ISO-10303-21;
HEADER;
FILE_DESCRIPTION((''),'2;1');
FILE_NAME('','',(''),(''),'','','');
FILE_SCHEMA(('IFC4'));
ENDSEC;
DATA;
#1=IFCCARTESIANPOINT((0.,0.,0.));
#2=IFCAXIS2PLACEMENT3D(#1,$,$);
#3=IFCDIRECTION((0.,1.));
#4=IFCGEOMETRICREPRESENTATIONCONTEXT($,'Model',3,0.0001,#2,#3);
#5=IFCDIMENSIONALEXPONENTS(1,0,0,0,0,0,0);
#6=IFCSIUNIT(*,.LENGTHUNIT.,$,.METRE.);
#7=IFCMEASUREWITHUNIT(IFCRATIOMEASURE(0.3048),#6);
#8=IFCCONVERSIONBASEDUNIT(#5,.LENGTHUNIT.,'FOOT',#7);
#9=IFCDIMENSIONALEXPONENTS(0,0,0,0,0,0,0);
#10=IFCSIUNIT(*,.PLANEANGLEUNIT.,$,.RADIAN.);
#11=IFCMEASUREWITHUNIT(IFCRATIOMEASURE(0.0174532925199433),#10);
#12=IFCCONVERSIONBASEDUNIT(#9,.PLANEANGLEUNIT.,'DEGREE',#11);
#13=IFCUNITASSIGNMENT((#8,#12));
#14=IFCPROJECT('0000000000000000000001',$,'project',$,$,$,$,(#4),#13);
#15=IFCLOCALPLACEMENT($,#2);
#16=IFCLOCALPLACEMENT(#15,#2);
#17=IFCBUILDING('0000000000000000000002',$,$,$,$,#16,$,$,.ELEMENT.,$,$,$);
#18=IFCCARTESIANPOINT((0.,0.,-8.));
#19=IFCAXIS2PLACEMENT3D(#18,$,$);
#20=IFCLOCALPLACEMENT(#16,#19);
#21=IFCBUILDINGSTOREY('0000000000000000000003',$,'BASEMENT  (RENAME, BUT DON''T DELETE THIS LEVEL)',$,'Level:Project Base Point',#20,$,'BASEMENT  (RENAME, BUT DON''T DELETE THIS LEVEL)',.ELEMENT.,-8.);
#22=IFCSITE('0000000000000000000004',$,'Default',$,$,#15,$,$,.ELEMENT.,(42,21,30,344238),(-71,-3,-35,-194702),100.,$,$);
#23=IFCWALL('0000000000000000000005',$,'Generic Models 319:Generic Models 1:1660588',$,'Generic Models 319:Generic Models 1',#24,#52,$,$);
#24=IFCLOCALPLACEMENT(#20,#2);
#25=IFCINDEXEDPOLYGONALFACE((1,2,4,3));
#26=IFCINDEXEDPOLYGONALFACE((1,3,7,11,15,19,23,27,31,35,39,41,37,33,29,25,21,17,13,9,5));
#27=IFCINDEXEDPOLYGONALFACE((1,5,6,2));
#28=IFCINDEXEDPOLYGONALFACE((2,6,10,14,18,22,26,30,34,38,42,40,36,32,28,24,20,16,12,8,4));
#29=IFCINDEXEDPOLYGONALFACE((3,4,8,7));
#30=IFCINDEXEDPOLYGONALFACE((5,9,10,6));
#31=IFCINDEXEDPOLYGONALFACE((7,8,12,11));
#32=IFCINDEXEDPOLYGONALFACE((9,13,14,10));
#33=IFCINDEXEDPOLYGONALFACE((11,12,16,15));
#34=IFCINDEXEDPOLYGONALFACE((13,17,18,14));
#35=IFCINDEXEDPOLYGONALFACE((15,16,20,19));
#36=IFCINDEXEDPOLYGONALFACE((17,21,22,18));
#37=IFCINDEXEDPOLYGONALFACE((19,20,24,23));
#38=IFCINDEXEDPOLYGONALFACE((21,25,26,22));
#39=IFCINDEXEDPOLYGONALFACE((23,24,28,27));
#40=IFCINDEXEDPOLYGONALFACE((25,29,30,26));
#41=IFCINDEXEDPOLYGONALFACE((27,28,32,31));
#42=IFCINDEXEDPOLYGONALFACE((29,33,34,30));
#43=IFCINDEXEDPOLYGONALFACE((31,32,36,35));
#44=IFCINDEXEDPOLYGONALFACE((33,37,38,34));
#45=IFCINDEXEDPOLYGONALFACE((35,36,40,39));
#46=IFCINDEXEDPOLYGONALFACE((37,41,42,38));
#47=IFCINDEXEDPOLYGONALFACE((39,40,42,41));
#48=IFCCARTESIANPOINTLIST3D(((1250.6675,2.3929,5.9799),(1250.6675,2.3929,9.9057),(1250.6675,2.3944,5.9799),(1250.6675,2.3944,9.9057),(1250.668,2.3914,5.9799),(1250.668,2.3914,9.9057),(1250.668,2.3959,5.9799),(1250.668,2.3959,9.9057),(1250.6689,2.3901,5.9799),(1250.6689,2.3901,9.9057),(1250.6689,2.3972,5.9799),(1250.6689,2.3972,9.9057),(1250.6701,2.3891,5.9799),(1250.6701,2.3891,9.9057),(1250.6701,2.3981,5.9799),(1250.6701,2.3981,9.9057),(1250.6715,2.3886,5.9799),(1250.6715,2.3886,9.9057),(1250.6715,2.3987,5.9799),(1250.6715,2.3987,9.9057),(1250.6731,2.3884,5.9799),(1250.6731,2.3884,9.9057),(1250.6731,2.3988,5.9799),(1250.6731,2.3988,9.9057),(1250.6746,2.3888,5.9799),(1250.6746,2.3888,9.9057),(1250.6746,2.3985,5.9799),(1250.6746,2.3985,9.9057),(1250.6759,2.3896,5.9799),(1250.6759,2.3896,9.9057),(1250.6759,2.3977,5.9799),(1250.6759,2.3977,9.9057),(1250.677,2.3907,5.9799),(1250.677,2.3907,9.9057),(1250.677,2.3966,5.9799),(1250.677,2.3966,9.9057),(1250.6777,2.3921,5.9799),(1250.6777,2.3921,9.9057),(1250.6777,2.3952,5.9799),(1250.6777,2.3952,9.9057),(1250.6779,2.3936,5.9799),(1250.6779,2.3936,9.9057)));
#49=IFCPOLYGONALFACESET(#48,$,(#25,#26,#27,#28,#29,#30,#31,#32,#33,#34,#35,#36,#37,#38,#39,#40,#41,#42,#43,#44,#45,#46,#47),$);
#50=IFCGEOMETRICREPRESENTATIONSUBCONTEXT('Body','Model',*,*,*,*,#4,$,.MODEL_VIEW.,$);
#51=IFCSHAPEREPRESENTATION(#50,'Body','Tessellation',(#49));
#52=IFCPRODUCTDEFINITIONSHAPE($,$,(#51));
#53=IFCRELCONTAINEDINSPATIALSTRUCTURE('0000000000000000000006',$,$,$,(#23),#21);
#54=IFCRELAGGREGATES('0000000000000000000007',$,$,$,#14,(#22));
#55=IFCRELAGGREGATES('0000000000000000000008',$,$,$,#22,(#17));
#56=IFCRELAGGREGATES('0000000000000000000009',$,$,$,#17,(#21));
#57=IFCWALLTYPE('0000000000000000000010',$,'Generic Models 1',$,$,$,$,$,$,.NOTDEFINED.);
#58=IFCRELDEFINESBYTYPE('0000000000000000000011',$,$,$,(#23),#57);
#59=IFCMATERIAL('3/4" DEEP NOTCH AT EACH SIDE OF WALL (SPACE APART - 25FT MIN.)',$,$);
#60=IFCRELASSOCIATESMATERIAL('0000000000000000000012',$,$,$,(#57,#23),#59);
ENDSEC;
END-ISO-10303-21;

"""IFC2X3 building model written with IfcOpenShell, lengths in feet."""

from ifc_helpers import new_model, entity, si_unit, converted_unit, direction, frame, origin, origin_2d_with_axis, place, context, subcontext, project, spatial, circle, extrude, material, type_object, element, save


model = new_model("IFC2X3")

# Units and contexts
model_context = context("Model", 3, precision=0.0001, world=origin(), true_north=direction((0.0, 1.0)))
body_context = subcontext(model_context, "Body", "Model", "MODEL_VIEW")
ifc_project = project(units=[converted_unit("LENGTHUNIT", "FOOT", entity("IfcRatioMeasure", 0.3048), si_unit("LENGTHUNIT", "METRE"), dimensions=[1, 0, 0, 0, 0, 0, 0]), converted_unit("PLANEANGLEUNIT", "DEGREE", entity("IfcRatioMeasure", 0.0174532925199433), si_unit("PLANEANGLEUNIT", "RADIAN"), dimensions=[0, 0, 0, 0, 0, 0, 0])], contexts=[model_context])

# Site, building, storey
site_placement = place(None, origin())
site = spatial("IfcSite", under=ifc_project, at=site_placement, Name="Default", CompositionType="ELEMENT", RefLatitude=(42, 21, 30, 344238), RefLongitude=(-71, -3, -35, -194702), RefElevation=100.0)
building_placement = place(site_placement, origin())
building = spatial("IfcBuilding", under=site, at=building_placement, CompositionType="ELEMENT")
storey_placement = place(building_placement, frame((0.0, 0.0, -8.0)))
storey = spatial("IfcBuildingStorey", under=building, at=storey_placement, Name="BASEMENT  (RENAME, BUT DON'T DELETE THIS LEVEL)", ObjectType="Level:Project Base Point", LongName="BASEMENT  (RENAME, BUT DON'T DELETE THIS LEVEL)", CompositionType="ELEMENT", Elevation=-8.0)

# Wall
ifc_material_1 = material(Name="3/4\" DEEP NOTCH AT EACH SIDE OF WALL (SPACE APART - 25FT MIN.)")
wall_type_1 = type_object("IfcWallType", Name="Generic Models 1", PredefinedType="NOTDEFINED", material=ifc_material_1)
wall_1_placement = place(storey_placement, frame((1250.6675, 2.3884, 5.9799), z_axis=(0.0, 0.0, 1.0), x_axis=(0.0, 1.0, 0.0)))
element("IfcWall", 1, at=wall_1_placement, inside=storey, type_object=wall_type_1, material=ifc_material_1, Name="Generic Models 319:Generic Models 1:1660588", ObjectType="Generic Models 319:Generic Models 1", context=body_context, shape_type="SweptSolid", body=[
    extrude(circle(Radius=0.0052, at=origin_2d_with_axis()), frame((0.0052, -0.0052, 0.0), z_axis=(0.0, 0.0, 1.0), x_axis=(0.0, -1.0, 0.0)), (0.0, 0.0, 1.0), 3.9258),
])

save(model, "model.ifc")
